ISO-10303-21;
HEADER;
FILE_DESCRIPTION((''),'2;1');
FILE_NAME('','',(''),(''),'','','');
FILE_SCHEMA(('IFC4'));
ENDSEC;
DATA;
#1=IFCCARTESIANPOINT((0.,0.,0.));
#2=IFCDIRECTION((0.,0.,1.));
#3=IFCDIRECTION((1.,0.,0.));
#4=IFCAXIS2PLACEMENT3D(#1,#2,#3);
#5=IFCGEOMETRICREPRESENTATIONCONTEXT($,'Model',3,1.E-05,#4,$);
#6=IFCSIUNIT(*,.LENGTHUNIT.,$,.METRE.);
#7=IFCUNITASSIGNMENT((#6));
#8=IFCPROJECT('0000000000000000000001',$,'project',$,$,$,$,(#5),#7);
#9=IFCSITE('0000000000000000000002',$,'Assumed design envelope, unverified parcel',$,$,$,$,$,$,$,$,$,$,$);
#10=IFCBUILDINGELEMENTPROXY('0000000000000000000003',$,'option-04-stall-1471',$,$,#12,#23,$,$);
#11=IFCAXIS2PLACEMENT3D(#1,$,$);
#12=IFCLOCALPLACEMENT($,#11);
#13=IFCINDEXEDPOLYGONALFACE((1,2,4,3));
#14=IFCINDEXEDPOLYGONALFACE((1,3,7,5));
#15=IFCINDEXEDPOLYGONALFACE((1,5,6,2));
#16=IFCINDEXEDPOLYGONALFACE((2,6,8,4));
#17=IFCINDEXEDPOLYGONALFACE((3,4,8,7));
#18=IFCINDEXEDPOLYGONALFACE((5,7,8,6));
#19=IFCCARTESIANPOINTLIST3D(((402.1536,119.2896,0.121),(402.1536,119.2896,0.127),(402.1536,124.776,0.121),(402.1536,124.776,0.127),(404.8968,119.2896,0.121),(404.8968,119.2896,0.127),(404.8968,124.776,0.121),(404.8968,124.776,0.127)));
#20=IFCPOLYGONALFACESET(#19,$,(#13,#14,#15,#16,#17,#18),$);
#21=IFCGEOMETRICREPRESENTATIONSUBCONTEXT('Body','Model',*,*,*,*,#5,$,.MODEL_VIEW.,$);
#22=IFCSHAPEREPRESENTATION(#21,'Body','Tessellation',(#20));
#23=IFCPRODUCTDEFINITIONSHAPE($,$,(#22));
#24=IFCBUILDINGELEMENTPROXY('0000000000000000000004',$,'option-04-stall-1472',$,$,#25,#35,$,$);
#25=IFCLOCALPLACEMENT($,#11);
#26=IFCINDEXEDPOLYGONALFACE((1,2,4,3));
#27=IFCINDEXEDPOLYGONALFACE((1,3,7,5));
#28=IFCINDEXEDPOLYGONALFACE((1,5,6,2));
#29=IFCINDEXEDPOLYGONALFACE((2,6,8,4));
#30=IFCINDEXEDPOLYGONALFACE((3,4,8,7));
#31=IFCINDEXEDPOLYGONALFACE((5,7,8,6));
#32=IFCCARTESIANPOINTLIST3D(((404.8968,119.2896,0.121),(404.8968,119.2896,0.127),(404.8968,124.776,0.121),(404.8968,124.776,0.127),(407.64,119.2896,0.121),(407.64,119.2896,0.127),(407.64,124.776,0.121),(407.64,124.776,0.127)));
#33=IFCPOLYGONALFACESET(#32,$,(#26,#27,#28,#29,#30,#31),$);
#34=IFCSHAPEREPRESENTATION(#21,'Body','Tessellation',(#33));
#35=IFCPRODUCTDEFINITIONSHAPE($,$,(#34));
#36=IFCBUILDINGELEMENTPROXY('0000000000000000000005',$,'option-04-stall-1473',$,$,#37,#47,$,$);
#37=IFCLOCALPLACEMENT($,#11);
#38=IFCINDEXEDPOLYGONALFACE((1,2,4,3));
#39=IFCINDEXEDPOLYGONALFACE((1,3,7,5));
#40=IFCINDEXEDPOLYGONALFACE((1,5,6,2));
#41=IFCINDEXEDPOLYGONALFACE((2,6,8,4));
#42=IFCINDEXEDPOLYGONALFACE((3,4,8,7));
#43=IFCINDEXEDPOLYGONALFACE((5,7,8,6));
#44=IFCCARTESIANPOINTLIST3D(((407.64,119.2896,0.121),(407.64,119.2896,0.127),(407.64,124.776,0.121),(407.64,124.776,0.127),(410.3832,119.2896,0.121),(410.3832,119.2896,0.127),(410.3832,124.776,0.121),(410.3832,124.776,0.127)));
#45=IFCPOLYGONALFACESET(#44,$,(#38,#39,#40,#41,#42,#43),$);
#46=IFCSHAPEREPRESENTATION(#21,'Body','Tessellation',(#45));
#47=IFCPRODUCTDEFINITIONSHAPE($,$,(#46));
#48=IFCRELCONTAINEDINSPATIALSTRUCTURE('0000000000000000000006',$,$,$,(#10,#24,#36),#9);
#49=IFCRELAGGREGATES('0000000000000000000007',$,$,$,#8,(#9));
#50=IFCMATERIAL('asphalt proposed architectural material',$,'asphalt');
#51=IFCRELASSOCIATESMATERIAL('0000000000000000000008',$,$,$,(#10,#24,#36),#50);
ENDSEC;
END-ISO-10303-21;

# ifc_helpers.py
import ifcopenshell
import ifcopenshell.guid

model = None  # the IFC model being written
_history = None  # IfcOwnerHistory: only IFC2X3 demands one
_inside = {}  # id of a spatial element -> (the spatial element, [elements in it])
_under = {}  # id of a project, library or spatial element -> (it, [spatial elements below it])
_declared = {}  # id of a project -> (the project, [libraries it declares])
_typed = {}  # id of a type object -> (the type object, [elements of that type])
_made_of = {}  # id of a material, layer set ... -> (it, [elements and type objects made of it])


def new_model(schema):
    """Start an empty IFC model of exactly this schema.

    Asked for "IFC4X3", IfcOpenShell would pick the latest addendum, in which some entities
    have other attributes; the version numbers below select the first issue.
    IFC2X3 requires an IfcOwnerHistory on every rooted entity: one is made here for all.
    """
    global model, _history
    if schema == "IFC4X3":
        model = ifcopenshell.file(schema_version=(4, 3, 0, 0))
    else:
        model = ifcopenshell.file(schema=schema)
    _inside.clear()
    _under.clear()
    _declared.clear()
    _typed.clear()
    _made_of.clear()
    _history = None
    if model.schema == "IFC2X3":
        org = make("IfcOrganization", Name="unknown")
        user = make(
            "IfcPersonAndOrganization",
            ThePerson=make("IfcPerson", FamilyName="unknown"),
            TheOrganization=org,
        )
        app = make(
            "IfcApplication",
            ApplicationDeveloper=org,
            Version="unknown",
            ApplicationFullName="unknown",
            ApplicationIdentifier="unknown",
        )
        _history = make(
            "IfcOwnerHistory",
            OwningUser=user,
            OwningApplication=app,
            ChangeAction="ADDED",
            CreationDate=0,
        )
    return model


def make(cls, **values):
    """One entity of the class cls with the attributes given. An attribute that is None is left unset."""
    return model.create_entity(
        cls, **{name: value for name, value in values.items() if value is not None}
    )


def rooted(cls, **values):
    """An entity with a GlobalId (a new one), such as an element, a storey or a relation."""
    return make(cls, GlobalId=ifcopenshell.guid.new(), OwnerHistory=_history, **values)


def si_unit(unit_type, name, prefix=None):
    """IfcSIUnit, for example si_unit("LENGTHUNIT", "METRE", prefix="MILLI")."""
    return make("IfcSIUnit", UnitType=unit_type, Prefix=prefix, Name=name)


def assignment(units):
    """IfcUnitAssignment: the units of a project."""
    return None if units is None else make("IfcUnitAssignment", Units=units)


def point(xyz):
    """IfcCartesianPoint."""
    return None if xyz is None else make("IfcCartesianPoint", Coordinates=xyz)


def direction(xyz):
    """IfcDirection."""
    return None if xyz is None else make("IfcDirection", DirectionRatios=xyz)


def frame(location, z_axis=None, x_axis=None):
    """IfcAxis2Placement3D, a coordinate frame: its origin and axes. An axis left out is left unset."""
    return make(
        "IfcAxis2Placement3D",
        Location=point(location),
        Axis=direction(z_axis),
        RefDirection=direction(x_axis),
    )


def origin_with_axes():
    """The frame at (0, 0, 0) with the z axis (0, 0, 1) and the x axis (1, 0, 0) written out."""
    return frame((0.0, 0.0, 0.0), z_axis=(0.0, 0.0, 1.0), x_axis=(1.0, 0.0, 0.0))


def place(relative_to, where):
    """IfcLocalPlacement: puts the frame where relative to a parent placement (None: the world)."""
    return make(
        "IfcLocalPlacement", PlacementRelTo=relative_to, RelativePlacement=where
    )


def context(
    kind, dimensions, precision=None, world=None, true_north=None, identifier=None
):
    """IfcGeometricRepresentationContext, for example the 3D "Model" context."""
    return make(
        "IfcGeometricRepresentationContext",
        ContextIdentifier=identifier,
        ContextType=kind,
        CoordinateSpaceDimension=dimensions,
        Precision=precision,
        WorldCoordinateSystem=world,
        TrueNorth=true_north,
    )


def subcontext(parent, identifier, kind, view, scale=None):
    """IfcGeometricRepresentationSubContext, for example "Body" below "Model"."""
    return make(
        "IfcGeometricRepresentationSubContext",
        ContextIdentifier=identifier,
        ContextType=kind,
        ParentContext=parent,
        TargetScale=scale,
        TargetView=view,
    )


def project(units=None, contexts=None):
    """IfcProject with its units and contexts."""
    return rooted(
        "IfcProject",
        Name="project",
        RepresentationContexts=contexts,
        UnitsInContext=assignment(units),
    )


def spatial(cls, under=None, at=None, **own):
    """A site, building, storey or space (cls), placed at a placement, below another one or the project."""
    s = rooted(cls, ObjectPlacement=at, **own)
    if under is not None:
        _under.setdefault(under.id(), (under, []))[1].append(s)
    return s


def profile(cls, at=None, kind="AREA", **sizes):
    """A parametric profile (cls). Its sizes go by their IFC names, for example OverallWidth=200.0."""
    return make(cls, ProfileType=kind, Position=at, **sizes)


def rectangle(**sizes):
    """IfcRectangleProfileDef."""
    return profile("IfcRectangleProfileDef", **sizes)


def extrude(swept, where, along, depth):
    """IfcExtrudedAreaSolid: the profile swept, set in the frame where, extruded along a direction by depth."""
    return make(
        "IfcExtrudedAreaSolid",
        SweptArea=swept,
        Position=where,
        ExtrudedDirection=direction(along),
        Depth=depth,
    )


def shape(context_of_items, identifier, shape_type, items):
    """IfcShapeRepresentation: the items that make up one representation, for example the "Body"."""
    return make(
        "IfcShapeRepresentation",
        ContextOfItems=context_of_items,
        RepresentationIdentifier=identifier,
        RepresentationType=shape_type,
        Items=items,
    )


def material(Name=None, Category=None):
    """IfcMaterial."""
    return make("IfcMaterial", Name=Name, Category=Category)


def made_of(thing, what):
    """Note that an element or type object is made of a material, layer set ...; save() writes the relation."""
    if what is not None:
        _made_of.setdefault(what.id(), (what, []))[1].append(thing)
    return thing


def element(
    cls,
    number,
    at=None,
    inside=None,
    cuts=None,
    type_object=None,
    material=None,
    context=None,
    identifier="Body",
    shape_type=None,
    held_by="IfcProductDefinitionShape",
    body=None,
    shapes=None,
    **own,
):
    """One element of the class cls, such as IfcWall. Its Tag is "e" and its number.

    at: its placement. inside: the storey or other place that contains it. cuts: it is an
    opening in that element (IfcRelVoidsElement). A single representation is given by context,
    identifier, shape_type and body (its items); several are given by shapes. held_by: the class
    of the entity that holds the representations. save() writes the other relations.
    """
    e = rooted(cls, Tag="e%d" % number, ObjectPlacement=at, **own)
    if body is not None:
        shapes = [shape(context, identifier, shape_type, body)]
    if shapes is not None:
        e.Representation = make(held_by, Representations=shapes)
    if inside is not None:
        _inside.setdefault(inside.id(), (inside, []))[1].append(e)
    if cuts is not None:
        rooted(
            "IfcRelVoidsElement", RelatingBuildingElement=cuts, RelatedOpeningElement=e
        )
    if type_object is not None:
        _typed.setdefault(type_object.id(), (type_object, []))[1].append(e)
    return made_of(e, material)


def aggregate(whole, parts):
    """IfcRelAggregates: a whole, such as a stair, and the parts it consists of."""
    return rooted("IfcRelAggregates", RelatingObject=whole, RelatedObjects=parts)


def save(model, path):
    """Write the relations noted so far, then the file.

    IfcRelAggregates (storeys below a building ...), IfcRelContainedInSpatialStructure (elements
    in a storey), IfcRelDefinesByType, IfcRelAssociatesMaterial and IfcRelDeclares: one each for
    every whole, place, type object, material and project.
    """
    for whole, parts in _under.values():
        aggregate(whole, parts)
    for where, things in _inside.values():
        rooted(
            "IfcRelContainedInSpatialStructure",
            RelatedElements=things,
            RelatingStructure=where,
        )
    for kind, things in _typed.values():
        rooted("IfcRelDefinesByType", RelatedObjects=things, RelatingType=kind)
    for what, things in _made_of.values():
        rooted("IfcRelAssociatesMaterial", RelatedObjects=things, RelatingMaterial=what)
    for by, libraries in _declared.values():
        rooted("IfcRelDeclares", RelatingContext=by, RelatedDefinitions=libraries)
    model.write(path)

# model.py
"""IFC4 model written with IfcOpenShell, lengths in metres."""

from ifc_helpers import new_model, si_unit, frame, origin_with_axes, place, context, subcontext, project, spatial, rectangle, extrude, material, element, save


model = new_model("IFC4")

# Units and contexts
model_context = context("Model", 3, precision=1e-05, world=origin_with_axes())
body_context = subcontext(model_context, "Body", "Model", "MODEL_VIEW")
ifc_project = project(units=[si_unit("LENGTHUNIT", "METRE")], contexts=[model_context])

# Site
site = spatial("IfcSite", under=ifc_project, Name="Assumed design envelope, unverified parcel")

# Building element proxies
ifc_material = material(Name="asphalt proposed architectural material", Category="asphalt")
for number, where, z_axis, x_axis, name in (
    (1, (403.5252, 122.0328, 0.121), (0.0, 0.0, 1.0), (1.0, 0.0, 0.0), "option-04-stall-1471"),
    (2, (406.2684, 122.0328, 0.121), (0.0, 0.0, 1.0), (1.0, 0.0, 0.0), "option-04-stall-1472"),
    (3, (409.0116, 122.0328, 0.121), (0.0, 0.0, 1.0), (1.0, 0.0, 0.0), "option-04-stall-1473"),
):
    element("IfcBuildingElementProxy", number, at=place(None, frame(where, z_axis=z_axis, x_axis=x_axis)), inside=site, material=ifc_material, Name=name, context=body_context, shape_type="SweptSolid", body=[
        extrude(rectangle(XDim=2.7432, YDim=5.4864), origin_with_axes(), (0.0, 0.0, 1.0), 0.006),
    ])

save(model, "model.ifc")
